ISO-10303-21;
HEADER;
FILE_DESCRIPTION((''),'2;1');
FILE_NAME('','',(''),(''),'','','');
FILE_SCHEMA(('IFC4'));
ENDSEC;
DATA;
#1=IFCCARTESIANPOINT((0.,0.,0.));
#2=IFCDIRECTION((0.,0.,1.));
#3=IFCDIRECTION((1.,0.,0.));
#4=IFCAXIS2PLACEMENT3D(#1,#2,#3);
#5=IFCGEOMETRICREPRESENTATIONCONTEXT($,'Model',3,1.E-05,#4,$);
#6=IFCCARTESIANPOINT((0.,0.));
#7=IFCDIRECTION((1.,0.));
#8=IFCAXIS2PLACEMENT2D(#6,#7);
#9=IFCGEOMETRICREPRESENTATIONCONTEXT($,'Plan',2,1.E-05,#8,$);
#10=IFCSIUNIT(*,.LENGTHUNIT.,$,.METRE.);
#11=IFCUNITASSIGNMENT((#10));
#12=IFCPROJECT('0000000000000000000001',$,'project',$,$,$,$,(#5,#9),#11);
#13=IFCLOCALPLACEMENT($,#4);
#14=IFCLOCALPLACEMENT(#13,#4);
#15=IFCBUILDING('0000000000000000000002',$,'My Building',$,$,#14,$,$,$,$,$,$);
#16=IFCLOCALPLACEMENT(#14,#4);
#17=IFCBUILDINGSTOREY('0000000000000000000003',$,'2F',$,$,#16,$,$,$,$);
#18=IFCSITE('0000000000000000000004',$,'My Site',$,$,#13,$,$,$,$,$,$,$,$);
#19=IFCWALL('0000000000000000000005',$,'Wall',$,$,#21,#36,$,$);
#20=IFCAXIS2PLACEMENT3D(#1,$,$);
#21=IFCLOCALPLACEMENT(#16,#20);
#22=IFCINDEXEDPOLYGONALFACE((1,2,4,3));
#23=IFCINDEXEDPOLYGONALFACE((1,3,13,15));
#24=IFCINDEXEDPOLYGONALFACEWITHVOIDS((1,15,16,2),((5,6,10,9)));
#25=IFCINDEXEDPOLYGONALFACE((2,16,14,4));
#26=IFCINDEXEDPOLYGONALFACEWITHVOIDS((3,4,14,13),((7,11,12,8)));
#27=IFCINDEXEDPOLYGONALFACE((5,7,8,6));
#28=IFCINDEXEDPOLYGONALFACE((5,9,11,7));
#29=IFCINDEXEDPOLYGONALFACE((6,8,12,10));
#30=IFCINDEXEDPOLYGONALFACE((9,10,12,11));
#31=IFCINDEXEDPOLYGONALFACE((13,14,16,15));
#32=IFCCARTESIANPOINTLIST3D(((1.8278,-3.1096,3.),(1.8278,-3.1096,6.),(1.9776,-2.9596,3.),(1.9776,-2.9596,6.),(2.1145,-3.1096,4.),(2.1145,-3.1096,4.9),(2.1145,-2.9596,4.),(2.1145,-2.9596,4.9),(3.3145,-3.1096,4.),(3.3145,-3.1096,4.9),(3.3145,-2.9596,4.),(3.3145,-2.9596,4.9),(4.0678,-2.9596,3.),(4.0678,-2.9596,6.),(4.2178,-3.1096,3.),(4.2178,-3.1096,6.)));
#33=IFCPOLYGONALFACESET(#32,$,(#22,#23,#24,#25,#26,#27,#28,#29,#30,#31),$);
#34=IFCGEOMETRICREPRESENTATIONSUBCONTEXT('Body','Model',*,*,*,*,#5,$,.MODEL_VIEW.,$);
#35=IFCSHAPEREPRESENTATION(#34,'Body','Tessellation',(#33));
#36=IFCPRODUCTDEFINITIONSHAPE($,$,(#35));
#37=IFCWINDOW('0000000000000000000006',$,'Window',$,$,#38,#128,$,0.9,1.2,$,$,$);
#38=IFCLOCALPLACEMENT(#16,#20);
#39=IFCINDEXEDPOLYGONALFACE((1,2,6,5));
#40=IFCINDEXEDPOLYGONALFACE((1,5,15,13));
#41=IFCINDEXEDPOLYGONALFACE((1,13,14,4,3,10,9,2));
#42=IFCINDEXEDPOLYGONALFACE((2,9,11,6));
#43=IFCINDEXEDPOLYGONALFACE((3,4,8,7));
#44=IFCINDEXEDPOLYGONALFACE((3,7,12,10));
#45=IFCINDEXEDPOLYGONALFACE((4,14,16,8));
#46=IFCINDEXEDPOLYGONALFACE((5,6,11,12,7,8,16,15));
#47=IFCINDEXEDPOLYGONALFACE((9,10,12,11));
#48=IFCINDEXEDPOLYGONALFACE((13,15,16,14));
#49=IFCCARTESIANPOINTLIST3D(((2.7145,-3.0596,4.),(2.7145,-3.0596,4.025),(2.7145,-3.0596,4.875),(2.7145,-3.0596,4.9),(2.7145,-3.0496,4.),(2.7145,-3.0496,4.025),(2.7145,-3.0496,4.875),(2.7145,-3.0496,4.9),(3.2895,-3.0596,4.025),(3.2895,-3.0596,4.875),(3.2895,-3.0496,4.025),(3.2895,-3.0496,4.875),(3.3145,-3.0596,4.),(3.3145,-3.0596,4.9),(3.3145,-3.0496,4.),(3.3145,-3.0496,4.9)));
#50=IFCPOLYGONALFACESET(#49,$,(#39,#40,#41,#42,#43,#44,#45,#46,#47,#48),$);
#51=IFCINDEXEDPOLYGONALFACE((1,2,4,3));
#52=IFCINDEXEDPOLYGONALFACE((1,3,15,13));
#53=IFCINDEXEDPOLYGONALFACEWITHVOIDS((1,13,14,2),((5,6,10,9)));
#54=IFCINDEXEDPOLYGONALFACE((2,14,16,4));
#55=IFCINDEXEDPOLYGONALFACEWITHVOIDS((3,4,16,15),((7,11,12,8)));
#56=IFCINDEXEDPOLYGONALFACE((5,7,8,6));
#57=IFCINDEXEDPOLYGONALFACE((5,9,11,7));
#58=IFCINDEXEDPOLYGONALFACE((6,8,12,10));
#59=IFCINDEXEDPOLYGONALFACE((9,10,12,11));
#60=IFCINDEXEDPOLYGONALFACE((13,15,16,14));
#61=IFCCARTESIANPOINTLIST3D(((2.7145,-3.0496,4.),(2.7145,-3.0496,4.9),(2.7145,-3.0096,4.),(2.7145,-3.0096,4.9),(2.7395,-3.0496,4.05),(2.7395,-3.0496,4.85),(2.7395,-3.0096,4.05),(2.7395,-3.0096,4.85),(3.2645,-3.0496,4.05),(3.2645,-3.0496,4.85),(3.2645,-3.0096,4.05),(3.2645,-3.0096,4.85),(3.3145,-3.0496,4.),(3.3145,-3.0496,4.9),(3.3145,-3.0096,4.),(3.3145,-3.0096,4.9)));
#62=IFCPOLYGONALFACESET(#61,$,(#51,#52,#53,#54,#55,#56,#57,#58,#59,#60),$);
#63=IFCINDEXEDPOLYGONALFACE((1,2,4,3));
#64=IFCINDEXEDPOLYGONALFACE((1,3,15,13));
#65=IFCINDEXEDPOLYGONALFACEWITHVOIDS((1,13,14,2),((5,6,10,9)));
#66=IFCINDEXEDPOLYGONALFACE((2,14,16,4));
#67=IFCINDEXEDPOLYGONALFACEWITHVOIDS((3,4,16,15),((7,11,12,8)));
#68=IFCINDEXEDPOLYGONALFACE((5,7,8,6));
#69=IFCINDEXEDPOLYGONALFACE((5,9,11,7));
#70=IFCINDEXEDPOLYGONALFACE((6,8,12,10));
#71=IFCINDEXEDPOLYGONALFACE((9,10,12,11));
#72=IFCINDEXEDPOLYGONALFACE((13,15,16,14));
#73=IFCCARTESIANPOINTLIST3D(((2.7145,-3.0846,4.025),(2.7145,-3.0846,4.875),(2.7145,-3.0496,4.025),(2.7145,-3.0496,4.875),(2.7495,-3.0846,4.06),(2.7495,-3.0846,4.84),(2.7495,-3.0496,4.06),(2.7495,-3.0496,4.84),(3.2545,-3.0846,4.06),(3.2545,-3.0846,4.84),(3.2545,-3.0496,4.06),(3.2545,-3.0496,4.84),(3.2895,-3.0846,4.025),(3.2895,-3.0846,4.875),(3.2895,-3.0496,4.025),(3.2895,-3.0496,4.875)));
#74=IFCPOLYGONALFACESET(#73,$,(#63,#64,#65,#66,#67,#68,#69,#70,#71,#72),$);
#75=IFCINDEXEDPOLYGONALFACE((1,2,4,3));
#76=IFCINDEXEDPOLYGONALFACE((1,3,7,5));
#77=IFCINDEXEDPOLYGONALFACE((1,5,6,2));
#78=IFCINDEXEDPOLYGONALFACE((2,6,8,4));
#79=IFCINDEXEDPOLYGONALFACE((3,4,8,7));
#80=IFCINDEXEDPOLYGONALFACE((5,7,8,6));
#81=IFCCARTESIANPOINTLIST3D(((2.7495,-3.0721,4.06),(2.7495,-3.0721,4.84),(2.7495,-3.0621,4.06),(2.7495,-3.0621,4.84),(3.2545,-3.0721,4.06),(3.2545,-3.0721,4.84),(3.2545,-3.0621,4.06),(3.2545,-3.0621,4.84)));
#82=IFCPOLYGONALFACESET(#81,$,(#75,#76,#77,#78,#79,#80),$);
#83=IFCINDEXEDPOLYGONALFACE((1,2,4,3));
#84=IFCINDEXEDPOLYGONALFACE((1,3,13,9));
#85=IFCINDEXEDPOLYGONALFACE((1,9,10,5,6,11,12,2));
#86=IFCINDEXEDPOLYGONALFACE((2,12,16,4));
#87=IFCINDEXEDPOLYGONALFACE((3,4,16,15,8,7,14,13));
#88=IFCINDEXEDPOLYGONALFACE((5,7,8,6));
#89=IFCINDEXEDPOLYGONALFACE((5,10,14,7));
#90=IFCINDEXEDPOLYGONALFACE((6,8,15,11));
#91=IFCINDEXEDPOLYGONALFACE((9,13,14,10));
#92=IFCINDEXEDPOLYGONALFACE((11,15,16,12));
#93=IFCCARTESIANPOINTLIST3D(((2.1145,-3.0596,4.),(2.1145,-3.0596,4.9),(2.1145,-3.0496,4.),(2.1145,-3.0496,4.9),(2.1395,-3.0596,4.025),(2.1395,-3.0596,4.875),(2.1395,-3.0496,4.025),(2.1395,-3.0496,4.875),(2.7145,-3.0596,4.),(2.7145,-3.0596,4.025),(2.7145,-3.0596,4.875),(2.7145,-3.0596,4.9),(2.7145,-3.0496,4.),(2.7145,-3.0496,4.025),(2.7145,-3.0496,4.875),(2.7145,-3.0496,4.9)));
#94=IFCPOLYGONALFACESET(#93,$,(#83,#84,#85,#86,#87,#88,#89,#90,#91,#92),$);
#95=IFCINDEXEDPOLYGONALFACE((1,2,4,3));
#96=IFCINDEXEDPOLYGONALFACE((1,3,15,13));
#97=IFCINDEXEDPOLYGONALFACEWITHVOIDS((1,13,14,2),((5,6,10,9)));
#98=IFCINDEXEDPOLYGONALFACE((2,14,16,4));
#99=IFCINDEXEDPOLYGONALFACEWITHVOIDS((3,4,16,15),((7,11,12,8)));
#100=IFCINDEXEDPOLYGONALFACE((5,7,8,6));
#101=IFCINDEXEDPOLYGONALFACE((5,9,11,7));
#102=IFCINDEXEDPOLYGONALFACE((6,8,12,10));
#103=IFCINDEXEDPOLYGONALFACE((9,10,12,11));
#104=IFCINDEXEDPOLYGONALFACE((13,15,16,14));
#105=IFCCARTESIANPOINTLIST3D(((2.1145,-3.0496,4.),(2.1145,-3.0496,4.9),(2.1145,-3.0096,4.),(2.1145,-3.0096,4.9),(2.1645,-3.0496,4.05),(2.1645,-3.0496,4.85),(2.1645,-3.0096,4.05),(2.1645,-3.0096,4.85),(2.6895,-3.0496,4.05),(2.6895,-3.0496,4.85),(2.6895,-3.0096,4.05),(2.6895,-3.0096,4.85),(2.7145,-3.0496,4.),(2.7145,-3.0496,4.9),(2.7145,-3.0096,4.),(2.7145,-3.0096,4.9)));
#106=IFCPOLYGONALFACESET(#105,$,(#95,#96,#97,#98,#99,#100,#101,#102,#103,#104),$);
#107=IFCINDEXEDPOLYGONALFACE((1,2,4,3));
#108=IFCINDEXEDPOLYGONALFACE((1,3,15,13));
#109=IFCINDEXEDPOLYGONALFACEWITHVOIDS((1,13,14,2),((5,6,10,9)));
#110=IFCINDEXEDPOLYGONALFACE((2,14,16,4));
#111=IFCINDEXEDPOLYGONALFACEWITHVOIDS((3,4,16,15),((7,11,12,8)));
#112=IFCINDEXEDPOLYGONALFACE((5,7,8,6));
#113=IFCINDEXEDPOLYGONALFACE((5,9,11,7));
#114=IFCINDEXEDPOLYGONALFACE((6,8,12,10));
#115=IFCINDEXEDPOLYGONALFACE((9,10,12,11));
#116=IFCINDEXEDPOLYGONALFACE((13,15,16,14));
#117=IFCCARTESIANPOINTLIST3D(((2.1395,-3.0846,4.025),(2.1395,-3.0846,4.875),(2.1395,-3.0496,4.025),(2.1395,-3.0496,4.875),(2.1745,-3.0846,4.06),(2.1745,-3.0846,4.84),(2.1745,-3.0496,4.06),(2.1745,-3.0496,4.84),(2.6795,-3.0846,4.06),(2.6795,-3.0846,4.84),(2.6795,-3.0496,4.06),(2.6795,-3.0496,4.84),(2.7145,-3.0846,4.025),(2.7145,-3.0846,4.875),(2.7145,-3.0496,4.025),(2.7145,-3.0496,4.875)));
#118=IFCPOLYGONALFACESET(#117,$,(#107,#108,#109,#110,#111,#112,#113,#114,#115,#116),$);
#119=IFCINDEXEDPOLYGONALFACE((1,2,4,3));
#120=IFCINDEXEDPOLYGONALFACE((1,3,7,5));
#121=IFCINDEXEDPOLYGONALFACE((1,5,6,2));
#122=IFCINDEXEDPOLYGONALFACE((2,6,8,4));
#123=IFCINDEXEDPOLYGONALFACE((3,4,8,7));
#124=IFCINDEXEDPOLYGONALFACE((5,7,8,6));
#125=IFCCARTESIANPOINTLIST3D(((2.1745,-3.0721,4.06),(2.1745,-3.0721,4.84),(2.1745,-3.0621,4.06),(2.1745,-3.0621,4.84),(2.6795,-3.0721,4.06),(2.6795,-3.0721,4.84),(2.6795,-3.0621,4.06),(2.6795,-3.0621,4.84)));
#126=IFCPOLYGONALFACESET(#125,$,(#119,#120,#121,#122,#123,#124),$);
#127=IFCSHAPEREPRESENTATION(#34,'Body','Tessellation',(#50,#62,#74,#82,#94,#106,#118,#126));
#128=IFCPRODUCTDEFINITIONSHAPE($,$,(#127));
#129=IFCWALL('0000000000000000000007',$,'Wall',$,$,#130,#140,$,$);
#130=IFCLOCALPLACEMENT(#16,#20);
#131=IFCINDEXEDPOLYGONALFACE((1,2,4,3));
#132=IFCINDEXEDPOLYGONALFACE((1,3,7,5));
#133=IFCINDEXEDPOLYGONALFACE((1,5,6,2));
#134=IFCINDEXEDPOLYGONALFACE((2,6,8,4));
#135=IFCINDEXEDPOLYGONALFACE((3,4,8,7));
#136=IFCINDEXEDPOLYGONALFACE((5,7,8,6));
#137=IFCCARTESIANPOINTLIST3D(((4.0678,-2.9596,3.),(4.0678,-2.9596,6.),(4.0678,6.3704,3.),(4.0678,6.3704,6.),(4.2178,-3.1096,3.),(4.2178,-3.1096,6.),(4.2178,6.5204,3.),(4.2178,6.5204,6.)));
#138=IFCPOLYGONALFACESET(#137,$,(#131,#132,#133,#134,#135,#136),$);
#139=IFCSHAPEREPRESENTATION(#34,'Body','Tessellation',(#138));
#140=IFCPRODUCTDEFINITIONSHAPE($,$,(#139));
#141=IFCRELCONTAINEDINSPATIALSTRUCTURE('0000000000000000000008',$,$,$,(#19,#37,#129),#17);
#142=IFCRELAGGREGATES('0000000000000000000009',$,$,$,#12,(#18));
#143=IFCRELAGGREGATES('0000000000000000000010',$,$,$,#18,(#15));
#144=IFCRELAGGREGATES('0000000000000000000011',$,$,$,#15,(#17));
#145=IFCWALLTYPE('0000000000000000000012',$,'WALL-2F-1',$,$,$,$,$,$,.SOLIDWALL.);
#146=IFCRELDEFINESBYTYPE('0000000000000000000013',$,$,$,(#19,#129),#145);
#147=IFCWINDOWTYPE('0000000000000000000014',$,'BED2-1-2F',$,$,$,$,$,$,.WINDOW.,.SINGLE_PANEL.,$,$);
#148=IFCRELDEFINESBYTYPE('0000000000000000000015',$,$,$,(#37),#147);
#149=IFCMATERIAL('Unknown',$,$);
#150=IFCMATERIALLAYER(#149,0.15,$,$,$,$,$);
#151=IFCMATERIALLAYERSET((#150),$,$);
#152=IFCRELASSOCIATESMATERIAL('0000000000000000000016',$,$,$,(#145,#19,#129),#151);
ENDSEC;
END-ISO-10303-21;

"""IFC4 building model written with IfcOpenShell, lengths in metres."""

from ifc_helpers import new_model, entity, si_unit, frame, origin_with_axes, origin_2d_with_axis, place, context, subcontext, project, spatial, line, indexed_curve, outline, extrude, shape, source, transform, mapped, material, layer, layer_set, layer_usage, type_object, type_shapes, element, fill, save


model = new_model("IFC4")

# Units and contexts
model_context = context("Model", 3, precision=1e-05, world=origin_with_axes())
plan_context = context("Plan", 2, precision=1e-05, world=origin_2d_with_axis())
body_context_1 = subcontext(model_context, "Body", "Model", "MODEL_VIEW")
body_context_2 = subcontext(plan_context, "Body", "Plan", "PLAN_VIEW")
ifc_project = project(units=[si_unit("LENGTHUNIT", "METRE")], contexts=[model_context, plan_context])

# Site, building, storey
site_placement = place(None, origin_with_axes())
site = spatial("IfcSite", under=ifc_project, at=site_placement, Name="My Site")
building_placement = place(site_placement, origin_with_axes())
building = spatial("IfcBuilding", under=site, at=building_placement, Name="My Building")
storey_placement = place(building_placement, origin_with_axes())
storey = spatial("IfcBuildingStorey", under=building, at=storey_placement, Name="2F")

# Shared definitions
ifc_material = material(Name="Unknown")

# Shared definitions
ifc_layer_1 = layer(ifc_material, 0.15)
ifc_layer_set_1 = layer_set([ifc_layer_1])
wall_type_1 = type_object("IfcWallType", Name="WALL-2F-1", PredefinedType="SOLIDWALL", material=ifc_layer_set_1)

# Wall, opening, window
ifc_layer_usage_1 = layer_usage(ifc_layer_set_1, "AXIS2", "POSITIVE", 0.0)
wall_1_placement = place(storey_placement, frame((1.8278, -3.1096, 3.0), z_axis=(0.0, 0.0, 1.0), x_axis=(1.0, 0.0, 0.0)))
wall_1 = element("IfcWall", 1, at=wall_1_placement, inside=storey, type_object=wall_type_1, material=ifc_layer_usage_1, Name="Wall", context=body_context_1, shape_type="SweptSolid", body=[
    extrude(outline(indexed_curve([(0.0, 0.0), (0.1498, 0.15), (2.24, 0.15), (2.39, 0.0)], segments=[line(1, 2, 3, 4, 1)])), origin_with_axes(), (0.0, 0.0, 1.0), 3.0),
])
shared_shape_1 = source(origin_with_axes(), body_context_1, "Body", "SweptSolid", [
    extrude(outline(indexed_curve([(0.0, 0.0), (1.2, 0.0), (1.2, 0.9), (0.0, 0.9)], segments=[line(1, 2, 3, 4, 1)])), frame((0.0, -0.6, 0.0), z_axis=(0.0, -1.0, 0.0), x_axis=(1.0, 0.0, 0.0)), (0.0, 0.0, -1.0), 1.2),
])
opening_1_placement = place(wall_1_placement, frame((1.4867, 0.15, 1.0), z_axis=(0.0, 0.0, 1.0), x_axis=(-1.0, 0.0, 0.0)))
opening_1 = element("IfcOpeningElement", 2, at=opening_1_placement, cuts=wall_1, PredefinedType="OPENING", context=body_context_1, shape_type="MappedRepresentation", body=[
    mapped(shared_shape_1, transform((0.0, 0.0, 0.0), x_axis=(1.0, 0.0, 0.0), y_axis=(0.0, 1.0, 0.0), z_axis=(0.0, 0.0, 1.0), scale=1.0)),
])
window_type = type_object("IfcWindowType", Name="BED2-1-2F", PartitioningType="SINGLE_PANEL", PredefinedType="WINDOW")
shared_shape_2 = source(origin_with_axes(), body_context_1, "Body", "SweptSolid", [
    extrude(outline(indexed_curve([(0.6, 0.0), (0.0, 0.0), (0.0, 0.9), (0.6, 0.9), (0.6, 0.875), (0.025, 0.875), (0.025, 0.025), (0.6, 0.025)], segments=[line(1, 2, 3, 4, 5, 6, 7, 8, 1)])), frame((0.0, 0.09, 0.0), z_axis=(0.0, -1.0, 0.0), x_axis=(1.0, 0.0, 0.0)), (0.0, 0.0, -1.0), 0.01),
    extrude(outline(indexed_curve([(0.0, 0.0), (0.6, 0.0), (0.6, 0.9), (0.0, 0.9)], segments=[line(1, 2, 3, 4, 1)]), holes=[indexed_curve([(0.05, 0.05), (0.575, 0.05), (0.575, 0.85), (0.05, 0.85)], segments=[line(1, 2, 3, 4, 1)])]), frame((0.0, 0.05, 0.0), z_axis=(0.0, -1.0, 0.0), x_axis=(1.0, 0.0, 0.0)), (0.0, 0.0, -1.0), 0.04),
    extrude(outline(indexed_curve([(0.0, 0.0), (0.575, 0.0), (0.575, 0.85), (0.0, 0.85)], segments=[line(1, 2, 3, 4, 1)]), holes=[indexed_curve([(0.035, 0.035), (0.54, 0.035), (0.54, 0.815), (0.035, 0.815)], segments=[line(1, 2, 3, 4, 1)])]), frame((0.025, 0.09, 0.025), z_axis=(0.0, -1.0, 0.0), x_axis=(1.0, 0.0, 0.0)), (0.0, 0.0, -1.0), 0.035),
    extrude(outline(indexed_curve([(0.035, 0.035), (0.54, 0.035), (0.54, 0.815), (0.035, 0.815)], segments=[line(1, 2, 3, 4, 1)])), frame((0.025, 0.1025, 0.025), z_axis=(0.0, -1.0, 0.0), x_axis=(1.0, 0.0, 0.0)), (0.0, 0.0, -1.0), 0.01),
    extrude(outline(indexed_curve([(0.0, 0.9), (0.6, 0.9), (0.6, 0.0), (0.0, 0.0), (0.0, 0.025), (0.575, 0.025), (0.575, 0.875), (0.0, 0.875)], segments=[line(1, 2, 3, 4, 5, 6, 7, 8, 1)])), frame((0.6, 0.09, 0.0), z_axis=(0.0, -1.0, 0.0), x_axis=(1.0, 0.0, 0.0)), (0.0, 0.0, -1.0), 0.01),
    extrude(outline(indexed_curve([(0.0, 0.0), (0.6, 0.0), (0.6, 0.9), (0.0, 0.9)], segments=[line(1, 2, 3, 4, 1)]), holes=[indexed_curve([(0.025, 0.05), (0.55, 0.05), (0.55, 0.85), (0.025, 0.85)], segments=[line(1, 2, 3, 4, 1)])]), frame((0.6, 0.05, 0.0), z_axis=(0.0, -1.0, 0.0), x_axis=(1.0, 0.0, 0.0)), (0.0, 0.0, -1.0), 0.04),
    extrude(outline(indexed_curve([(0.0, 0.0), (0.575, 0.0), (0.575, 0.85), (0.0, 0.85)], segments=[line(1, 2, 3, 4, 1)]), holes=[indexed_curve([(0.035, 0.035), (0.54, 0.035), (0.54, 0.815), (0.035, 0.815)], segments=[line(1, 2, 3, 4, 1)])]), frame((0.6, 0.09, 0.025), z_axis=(0.0, -1.0, 0.0), x_axis=(1.0, 0.0, 0.0)), (0.0, 0.0, -1.0), 0.035),
    extrude(outline(indexed_curve([(0.035, 0.035), (0.54, 0.035), (0.54, 0.815), (0.035, 0.815)], segments=[line(1, 2, 3, 4, 1)])), frame((0.6, 0.1025, 0.025), z_axis=(0.0, -1.0, 0.0), x_axis=(1.0, 0.0, 0.0)), (0.0, 0.0, -1.0), 0.01),
])
shared_shape_3 = source(origin_with_axes(), body_context_2, "Body", "Curve2D", [
    entity("IfcIndexedPolyCurve", entity("IfcCartesianPointList2D", [[0.05, 0.05], [0.575, 0.05]])),
    entity("IfcIndexedPolyCurve", entity("IfcCartesianPointList2D", [[0.0, 0.1], [0.025, 0.1], [0.025, 0.09], [0.05, 0.09], [0.05, 0.05], [0.0, 0.05]]), [entity("IfcLineIndex", [1, 2, 3, 4, 5, 6, 1])]),
    entity("IfcIndexedPolyCurve", entity("IfcCartesianPointList2D", [[0.6, 0.1], [0.6, 0.1], [0.6, 0.09], [0.575, 0.09], [0.575, 0.05], [0.6, 0.05]])),
    entity("IfcIndexedPolyCurve", entity("IfcCartesianPointList2D", [[0.025, 0.09], [0.06, 0.09], [0.06, 0.125], [0.025, 0.125]]), [entity("IfcLineIndex", [1, 2, 3, 4, 1])]),
    entity("IfcIndexedPolyCurve", entity("IfcCartesianPointList2D", [[0.6, 0.09], [0.565, 0.09], [0.565, 0.125], [0.6, 0.125]]), [entity("IfcLineIndex", [1, 2, 3, 4, 1])]),
    entity("IfcIndexedPolyCurve", entity("IfcCartesianPointList2D", [[0.06, 0.09], [0.565, 0.09]])),
    entity("IfcIndexedPolyCurve", entity("IfcCartesianPointList2D", [[0.06, 0.125], [0.565, 0.125]])),
    entity("IfcIndexedPolyCurve", entity("IfcCartesianPointList2D", [[0.06, 0.1075], [0.565, 0.1075]])),
    entity("IfcIndexedPolyCurve", entity("IfcCartesianPointList2D", [[0.625, 0.05], [1.15, 0.05]])),
    entity("IfcIndexedPolyCurve", entity("IfcCartesianPointList2D", [[0.6, 0.1], [0.6, 0.1], [0.6, 0.09], [0.625, 0.09], [0.625, 0.05], [0.6, 0.05]])),
    entity("IfcIndexedPolyCurve", entity("IfcCartesianPointList2D", [[1.2, 0.1], [1.175, 0.1], [1.175, 0.09], [1.15, 0.09], [1.15, 0.05], [1.2, 0.05]]), [entity("IfcLineIndex", [1, 2, 3, 4, 5, 6, 1])]),
    entity("IfcIndexedPolyCurve", entity("IfcCartesianPointList2D", [[0.6, 0.09], [0.635, 0.09], [0.635, 0.125], [0.6, 0.125]]), [entity("IfcLineIndex", [1, 2, 3, 4, 1])]),
    entity("IfcIndexedPolyCurve", entity("IfcCartesianPointList2D", [[1.175, 0.09], [1.14, 0.09], [1.14, 0.125], [1.175, 0.125]]), [entity("IfcLineIndex", [1, 2, 3, 4, 1])]),
    entity("IfcIndexedPolyCurve", entity("IfcCartesianPointList2D", [[0.635, 0.09], [1.14, 0.09]])),
    entity("IfcIndexedPolyCurve", entity("IfcCartesianPointList2D", [[0.635, 0.125], [1.14, 0.125]])),
    entity("IfcIndexedPolyCurve", entity("IfcCartesianPointList2D", [[0.635, 0.1075], [1.14, 0.1075]])),
])
type_shapes(window_type, [shared_shape_2, shared_shape_3])
window_placement = place(opening_1_placement, frame((0.0, 0.0, 0.0), z_axis=(0.0, 0.0, 1.0), x_axis=(1.0, 0.0, 0.0)))
window = element("IfcWindow", 3, at=window_placement, inside=storey, type_object=window_type, Name="Window", OverallHeight=0.9, OverallWidth=1.2, shapes=[
    shape(body_context_1, "Body", "MappedRepresentation", [mapped(shared_shape_2, transform((0.0, 0.0, 0.0), x_axis=(1.0, 0.0, 0.0), y_axis=(0.0, 1.0, 0.0), z_axis=(0.0, 0.0, 1.0), scale=1.0))]),
    shape(body_context_2, "Body", "MappedRepresentation", [mapped(shared_shape_3, transform((0.0, 0.0, 0.0), x_axis=(1.0, 0.0, 0.0), y_axis=(0.0, 1.0, 0.0), z_axis=(0.0, 0.0, 1.0), scale=1.0))]),
])
fill(opening_1, window)

# Wall
ifc_layer_usage_2 = layer_usage(ifc_layer_set_1, "AXIS2", "POSITIVE", 0.0)
wall_2_placement = place(storey_placement, frame((4.2178, -3.1096, 3.0), z_axis=(0.0, 0.0, 1.0), x_axis=(0.0, 1.0, 0.0)))
element("IfcWall", 4, at=wall_2_placement, inside=storey, type_object=wall_type_1, material=ifc_layer_usage_2, Name="Wall", context=body_context_1, shape_type="SweptSolid", body=[
    extrude(outline(indexed_curve([(0.0, 0.0), (0.15, 0.15), (9.48, 0.15), (9.63, 0.0)], segments=[line(1, 2, 3, 4, 1)])), origin_with_axes(), (0.0, 0.0, 1.0), 3.0),
])

save(model, "model.ifc")
